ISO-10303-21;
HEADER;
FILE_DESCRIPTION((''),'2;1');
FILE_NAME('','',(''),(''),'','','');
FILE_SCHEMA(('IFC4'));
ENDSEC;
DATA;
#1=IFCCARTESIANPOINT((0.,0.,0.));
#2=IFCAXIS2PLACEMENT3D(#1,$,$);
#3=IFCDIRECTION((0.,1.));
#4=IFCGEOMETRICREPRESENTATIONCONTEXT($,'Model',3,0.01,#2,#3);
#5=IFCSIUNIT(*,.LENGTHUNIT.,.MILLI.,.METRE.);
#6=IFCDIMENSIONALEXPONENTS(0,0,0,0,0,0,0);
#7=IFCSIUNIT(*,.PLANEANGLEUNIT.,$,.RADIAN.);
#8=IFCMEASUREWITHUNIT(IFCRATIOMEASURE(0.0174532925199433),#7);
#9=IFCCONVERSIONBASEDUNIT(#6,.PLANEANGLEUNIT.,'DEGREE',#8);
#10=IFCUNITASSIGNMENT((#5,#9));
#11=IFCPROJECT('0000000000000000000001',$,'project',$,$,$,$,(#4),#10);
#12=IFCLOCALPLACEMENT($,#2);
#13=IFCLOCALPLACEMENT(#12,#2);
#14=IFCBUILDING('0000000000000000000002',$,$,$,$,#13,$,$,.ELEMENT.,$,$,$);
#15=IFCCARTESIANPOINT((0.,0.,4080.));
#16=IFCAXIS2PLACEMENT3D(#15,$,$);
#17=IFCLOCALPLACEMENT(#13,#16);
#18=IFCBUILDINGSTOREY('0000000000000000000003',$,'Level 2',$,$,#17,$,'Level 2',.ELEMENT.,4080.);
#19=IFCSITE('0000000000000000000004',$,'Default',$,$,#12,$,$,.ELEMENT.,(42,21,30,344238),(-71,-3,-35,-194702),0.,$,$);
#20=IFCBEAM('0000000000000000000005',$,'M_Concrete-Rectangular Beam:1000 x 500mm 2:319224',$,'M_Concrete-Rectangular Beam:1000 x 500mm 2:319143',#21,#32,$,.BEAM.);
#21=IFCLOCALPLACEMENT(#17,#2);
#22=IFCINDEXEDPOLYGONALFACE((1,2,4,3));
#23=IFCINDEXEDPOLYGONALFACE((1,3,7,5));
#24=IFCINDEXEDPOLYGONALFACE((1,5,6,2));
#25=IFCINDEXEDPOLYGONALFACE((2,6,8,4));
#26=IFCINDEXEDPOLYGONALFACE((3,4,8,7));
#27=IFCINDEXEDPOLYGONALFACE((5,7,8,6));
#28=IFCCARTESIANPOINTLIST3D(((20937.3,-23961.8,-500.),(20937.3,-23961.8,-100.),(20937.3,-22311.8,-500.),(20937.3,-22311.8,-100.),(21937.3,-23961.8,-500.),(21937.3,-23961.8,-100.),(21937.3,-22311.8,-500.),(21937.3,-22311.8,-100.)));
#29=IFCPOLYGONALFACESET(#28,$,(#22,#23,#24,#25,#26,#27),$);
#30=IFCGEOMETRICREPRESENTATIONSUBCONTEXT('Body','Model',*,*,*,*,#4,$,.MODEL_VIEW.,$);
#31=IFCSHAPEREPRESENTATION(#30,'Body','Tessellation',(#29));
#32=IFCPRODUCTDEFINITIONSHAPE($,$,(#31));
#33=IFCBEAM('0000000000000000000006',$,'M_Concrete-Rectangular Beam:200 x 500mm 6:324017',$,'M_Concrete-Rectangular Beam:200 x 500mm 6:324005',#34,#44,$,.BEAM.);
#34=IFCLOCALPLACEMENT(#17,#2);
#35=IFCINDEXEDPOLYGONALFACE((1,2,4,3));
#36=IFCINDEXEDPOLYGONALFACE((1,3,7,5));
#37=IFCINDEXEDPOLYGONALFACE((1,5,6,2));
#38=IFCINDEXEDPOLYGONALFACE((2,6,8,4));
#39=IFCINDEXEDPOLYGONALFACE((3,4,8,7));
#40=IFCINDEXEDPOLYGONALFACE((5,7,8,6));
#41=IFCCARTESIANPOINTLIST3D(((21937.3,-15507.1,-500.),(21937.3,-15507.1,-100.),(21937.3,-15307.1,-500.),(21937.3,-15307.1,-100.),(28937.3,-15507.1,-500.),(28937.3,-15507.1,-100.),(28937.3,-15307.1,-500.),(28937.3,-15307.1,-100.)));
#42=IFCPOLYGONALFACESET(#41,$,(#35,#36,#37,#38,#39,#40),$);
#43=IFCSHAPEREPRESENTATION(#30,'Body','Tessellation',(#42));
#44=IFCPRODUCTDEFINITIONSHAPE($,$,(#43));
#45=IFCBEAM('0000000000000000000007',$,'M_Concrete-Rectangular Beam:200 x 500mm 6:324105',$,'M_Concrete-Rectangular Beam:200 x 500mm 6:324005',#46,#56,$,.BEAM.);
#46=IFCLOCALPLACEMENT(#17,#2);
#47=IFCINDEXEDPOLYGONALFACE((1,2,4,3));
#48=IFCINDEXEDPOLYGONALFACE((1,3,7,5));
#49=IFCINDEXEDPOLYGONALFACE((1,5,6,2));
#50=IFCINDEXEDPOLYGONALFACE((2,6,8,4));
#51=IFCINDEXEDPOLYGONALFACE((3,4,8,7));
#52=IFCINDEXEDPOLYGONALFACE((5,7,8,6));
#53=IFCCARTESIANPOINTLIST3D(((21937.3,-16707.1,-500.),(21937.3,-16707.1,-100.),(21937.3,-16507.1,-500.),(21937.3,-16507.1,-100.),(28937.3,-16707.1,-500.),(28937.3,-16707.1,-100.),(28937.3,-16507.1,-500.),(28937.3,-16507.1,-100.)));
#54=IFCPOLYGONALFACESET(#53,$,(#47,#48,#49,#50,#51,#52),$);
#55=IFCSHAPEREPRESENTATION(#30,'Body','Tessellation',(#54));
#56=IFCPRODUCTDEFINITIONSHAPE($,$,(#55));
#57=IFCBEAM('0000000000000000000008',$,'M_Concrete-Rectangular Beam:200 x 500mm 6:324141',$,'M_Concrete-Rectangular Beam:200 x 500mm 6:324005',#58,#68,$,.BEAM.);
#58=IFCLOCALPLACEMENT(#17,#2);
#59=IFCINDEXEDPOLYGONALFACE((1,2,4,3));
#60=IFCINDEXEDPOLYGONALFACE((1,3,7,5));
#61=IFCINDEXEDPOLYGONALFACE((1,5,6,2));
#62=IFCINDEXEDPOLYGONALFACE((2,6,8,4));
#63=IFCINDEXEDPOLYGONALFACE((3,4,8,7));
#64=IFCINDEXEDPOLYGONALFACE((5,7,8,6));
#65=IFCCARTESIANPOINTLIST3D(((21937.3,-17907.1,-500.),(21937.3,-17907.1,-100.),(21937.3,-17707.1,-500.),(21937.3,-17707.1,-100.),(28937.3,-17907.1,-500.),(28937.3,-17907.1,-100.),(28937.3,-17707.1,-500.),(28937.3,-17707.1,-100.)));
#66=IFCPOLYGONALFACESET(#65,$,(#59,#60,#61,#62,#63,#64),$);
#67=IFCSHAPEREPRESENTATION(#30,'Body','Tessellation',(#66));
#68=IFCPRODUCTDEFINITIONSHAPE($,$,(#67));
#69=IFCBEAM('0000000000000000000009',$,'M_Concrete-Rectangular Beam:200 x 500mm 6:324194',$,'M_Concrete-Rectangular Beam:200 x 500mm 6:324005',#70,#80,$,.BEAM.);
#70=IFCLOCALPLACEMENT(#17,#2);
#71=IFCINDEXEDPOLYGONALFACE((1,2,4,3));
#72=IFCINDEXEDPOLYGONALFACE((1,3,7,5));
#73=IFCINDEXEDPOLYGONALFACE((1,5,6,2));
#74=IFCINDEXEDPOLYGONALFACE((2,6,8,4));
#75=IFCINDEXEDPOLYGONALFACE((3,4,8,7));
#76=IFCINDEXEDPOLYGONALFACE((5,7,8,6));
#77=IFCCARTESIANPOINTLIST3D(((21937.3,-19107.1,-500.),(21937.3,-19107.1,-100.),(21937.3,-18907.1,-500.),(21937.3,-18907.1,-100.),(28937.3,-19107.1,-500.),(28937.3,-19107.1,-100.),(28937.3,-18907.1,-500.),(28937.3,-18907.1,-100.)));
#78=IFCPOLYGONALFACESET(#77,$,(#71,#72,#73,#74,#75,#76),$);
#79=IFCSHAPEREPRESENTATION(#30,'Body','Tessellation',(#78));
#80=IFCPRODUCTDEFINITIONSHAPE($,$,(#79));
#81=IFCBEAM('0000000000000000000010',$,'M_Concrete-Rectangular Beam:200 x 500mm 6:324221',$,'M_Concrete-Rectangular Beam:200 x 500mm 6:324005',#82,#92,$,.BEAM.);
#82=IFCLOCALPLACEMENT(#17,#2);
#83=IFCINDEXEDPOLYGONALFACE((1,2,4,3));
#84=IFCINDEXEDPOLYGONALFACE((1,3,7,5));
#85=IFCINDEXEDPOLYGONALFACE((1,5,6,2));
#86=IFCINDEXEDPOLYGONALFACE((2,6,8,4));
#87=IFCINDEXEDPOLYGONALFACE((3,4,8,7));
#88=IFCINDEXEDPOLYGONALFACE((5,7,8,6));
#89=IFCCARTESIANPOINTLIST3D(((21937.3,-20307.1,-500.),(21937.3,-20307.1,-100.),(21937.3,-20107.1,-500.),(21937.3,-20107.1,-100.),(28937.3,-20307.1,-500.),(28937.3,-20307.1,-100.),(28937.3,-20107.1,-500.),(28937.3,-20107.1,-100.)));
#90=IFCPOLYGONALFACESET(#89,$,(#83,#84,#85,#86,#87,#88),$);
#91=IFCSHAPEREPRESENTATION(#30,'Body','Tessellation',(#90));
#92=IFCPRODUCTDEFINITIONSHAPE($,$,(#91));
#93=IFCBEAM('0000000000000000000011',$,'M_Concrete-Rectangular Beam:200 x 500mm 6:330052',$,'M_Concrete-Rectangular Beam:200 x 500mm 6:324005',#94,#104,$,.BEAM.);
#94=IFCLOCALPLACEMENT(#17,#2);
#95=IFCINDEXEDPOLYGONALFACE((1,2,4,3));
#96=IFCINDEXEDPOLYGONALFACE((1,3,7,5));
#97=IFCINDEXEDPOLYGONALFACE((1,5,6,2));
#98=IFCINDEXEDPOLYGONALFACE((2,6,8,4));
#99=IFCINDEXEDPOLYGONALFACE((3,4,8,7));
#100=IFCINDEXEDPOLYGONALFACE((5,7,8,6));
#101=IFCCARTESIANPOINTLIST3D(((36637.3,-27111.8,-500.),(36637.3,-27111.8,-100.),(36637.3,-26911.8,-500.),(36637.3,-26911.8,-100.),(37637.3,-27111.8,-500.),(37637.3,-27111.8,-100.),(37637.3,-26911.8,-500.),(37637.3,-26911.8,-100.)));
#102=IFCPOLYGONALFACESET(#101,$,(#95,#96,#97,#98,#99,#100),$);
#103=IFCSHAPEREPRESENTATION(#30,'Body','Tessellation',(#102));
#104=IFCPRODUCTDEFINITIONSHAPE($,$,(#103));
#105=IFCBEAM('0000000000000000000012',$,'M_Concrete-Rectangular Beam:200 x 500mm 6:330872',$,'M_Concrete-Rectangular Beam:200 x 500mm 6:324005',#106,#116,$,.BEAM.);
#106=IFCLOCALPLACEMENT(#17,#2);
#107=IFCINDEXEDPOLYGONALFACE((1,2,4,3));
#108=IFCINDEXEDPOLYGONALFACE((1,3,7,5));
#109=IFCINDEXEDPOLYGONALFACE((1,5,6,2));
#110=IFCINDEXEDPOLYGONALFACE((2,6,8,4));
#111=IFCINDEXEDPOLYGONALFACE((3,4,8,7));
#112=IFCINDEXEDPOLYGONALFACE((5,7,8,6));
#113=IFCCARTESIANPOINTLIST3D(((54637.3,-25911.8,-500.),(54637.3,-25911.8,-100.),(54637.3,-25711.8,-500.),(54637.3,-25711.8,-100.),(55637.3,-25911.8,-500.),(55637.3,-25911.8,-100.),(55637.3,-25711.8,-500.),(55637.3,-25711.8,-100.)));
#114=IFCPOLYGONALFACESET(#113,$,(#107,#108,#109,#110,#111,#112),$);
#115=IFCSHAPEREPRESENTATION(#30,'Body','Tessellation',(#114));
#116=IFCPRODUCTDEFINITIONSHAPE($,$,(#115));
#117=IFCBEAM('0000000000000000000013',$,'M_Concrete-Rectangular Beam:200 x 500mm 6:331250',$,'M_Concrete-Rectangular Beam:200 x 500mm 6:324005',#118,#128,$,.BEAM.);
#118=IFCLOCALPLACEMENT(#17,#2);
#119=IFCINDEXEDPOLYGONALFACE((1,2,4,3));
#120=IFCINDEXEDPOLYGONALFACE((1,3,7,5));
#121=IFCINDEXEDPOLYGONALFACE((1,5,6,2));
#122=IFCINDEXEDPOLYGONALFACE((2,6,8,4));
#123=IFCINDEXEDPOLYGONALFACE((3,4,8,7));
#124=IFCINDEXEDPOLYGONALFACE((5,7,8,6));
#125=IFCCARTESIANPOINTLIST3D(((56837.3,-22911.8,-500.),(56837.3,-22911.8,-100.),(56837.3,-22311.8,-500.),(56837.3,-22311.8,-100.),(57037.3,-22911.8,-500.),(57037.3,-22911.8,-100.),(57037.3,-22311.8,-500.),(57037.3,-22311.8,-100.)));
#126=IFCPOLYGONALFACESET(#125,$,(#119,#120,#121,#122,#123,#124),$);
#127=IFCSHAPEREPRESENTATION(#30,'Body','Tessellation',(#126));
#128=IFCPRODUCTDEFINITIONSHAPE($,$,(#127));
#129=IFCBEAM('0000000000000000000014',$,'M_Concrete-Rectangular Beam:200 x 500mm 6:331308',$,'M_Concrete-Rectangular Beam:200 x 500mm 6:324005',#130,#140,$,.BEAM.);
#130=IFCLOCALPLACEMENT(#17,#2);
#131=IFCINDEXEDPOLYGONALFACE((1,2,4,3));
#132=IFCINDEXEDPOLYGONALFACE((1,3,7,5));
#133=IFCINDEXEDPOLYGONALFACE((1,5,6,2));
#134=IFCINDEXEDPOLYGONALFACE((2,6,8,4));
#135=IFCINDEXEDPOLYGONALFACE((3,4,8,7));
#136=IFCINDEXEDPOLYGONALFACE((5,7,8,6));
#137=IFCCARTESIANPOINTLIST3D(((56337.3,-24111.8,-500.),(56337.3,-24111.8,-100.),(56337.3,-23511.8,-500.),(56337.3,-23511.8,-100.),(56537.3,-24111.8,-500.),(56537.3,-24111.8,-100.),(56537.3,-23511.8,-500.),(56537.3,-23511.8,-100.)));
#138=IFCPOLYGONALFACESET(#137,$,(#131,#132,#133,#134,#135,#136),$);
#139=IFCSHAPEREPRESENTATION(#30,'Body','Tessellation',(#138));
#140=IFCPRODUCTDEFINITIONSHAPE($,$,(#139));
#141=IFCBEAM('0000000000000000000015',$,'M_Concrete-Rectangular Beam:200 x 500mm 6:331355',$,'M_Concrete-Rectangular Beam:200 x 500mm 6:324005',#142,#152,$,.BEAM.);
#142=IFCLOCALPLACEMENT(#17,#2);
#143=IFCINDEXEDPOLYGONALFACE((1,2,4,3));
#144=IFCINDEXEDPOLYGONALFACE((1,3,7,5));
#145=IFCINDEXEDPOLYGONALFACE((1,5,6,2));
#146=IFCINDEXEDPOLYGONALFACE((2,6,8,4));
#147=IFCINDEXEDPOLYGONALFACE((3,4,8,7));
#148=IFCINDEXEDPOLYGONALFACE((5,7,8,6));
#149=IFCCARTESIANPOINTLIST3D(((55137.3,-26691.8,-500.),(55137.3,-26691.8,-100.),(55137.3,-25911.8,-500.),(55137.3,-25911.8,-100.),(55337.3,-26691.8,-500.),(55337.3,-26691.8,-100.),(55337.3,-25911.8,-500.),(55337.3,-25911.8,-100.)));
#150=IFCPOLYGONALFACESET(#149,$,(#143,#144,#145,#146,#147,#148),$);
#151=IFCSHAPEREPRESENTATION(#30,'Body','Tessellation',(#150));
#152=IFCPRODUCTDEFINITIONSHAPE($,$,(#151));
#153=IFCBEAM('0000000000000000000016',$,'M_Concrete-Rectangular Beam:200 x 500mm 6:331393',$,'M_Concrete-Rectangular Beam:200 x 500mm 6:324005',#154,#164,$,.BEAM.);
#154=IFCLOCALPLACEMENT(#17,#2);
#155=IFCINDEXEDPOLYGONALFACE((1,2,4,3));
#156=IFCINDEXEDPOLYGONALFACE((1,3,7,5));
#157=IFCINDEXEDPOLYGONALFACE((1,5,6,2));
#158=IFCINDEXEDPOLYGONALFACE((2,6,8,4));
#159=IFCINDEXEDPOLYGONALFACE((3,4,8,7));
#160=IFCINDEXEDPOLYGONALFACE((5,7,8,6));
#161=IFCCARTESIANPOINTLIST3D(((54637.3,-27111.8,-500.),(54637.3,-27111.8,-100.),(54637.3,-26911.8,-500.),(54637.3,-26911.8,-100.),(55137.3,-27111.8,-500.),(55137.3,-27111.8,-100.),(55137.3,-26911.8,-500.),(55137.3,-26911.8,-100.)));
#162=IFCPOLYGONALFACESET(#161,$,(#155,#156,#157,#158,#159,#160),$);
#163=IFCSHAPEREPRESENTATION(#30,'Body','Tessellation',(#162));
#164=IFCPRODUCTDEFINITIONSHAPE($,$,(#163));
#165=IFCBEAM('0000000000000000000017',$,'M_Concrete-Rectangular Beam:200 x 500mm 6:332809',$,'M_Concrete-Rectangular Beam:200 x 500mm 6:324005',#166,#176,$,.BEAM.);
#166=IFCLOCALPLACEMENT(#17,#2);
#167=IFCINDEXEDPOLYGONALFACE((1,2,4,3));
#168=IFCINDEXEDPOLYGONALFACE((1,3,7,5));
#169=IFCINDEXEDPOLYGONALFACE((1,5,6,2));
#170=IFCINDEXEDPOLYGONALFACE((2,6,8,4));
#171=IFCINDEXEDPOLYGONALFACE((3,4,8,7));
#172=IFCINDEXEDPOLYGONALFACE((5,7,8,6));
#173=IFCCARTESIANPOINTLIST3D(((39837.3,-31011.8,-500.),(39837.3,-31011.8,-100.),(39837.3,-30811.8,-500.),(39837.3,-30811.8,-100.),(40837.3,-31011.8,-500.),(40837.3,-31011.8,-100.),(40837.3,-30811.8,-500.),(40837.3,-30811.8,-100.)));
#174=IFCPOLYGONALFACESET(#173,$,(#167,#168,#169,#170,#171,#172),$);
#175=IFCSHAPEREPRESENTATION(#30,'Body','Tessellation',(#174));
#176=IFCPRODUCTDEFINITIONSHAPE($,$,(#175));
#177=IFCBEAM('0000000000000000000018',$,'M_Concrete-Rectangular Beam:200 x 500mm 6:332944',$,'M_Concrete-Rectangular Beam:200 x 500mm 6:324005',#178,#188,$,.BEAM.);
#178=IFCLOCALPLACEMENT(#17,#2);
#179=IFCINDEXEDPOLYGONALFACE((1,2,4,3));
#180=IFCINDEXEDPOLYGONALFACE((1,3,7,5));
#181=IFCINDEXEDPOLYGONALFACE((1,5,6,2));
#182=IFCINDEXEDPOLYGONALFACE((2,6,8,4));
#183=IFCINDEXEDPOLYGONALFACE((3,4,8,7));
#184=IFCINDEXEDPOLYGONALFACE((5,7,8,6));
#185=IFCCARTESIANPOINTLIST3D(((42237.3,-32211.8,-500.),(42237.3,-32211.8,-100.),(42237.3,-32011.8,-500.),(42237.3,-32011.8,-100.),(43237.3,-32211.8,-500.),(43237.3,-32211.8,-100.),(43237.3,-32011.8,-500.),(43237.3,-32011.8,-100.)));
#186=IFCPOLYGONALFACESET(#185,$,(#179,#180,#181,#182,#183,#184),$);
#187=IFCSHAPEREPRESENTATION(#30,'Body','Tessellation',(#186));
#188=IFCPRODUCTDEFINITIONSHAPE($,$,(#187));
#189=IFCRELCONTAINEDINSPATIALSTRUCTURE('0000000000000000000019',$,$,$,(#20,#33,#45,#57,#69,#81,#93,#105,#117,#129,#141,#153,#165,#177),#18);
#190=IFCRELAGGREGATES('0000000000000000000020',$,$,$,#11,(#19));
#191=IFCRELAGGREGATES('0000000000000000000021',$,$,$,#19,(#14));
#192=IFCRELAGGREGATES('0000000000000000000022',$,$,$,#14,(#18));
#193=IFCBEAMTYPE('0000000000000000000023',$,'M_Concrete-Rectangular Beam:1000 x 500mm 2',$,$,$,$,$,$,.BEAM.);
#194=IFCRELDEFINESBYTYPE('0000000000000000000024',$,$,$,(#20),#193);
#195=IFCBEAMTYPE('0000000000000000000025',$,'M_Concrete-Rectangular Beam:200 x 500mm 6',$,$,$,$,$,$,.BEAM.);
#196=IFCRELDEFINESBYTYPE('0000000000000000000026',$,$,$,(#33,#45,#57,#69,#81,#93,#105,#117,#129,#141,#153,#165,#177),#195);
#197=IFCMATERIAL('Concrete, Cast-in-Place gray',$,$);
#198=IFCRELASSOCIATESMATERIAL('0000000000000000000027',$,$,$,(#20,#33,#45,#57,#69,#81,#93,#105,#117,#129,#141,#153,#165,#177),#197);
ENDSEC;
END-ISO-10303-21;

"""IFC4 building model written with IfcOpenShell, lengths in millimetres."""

from ifc_helpers import new_model, entity, si_unit, converted_unit, direction, frame, frame_2d, origin, place, context, subcontext, project, spatial, rectangle, extrude, material, type_object, element, save


model = new_model("IFC4")

# Units and contexts
model_context = context("Model", 3, precision=0.01, world=origin(), true_north=direction((0.0, 1.0)))
body_context = subcontext(model_context, "Body", "Model", "MODEL_VIEW")
ifc_project = project(units=[si_unit("LENGTHUNIT", "METRE", prefix="MILLI"), converted_unit("PLANEANGLEUNIT", "DEGREE", entity("IfcRatioMeasure", 0.0174532925199433), si_unit("PLANEANGLEUNIT", "RADIAN"), dimensions=[0, 0, 0, 0, 0, 0, 0])], contexts=[model_context])

# Site, building, storey
site_placement = place(None, origin())
site = spatial("IfcSite", under=ifc_project, at=site_placement, Name="Default", CompositionType="ELEMENT", RefLatitude=(42, 21, 30, 344238), RefLongitude=(-71, -3, -35, -194702), RefElevation=0.0)
building_placement = place(site_placement, origin())
building = spatial("IfcBuilding", under=site, at=building_placement, CompositionType="ELEMENT")
storey_placement = place(building_placement, frame((0.0, 0.0, 4080.0)))
storey = spatial("IfcBuildingStorey", under=building, at=storey_placement, Name="Level 2", LongName="Level 2", CompositionType="ELEMENT", Elevation=4080.0)

# Beams
ifc_material_1 = material(Name="Concrete, Cast-in-Place gray")
beam_type_1 = type_object("IfcBeamType", Name="M_Concrete-Rectangular Beam:1000 x 500mm 2", PredefinedType="BEAM")
beam_1_placement = place(storey_placement, frame((21437.3, -21811.8, 0.0), z_axis=(0.0, 0.0, 1.0), x_axis=(0.0, -1.0, 0.0)))
element("IfcBeam", 1, at=beam_1_placement, inside=storey, type_object=beam_type_1, material=ifc_material_1, Name="M_Concrete-Rectangular Beam:1000 x 500mm 2:319224", ObjectType="M_Concrete-Rectangular Beam:1000 x 500mm 2:319143", PredefinedType="BEAM", context=body_context, shape_type="SweptSolid", body=[
    extrude(rectangle(XDim=400.0, YDim=1000.0, at=frame_2d((0.0, 0.0), x_axis=(1.0, 0.0))), frame((500.0, 0.0, -300.0), z_axis=(1.0, 0.0, 0.0), x_axis=(0.0, 0.0, -1.0)), (0.0, 0.0, 1.0), 1650.0),
])
beam_type_2 = type_object("IfcBeamType", Name="M_Concrete-Rectangular Beam:200 x 500mm 6", PredefinedType="BEAM")
for number, where, name in (
    (2, (21437.3, -15407.1, 0.0), "M_Concrete-Rectangular Beam:200 x 500mm 6:324017"),
    (3, (21437.3, -16607.1, 0.0), "M_Concrete-Rectangular Beam:200 x 500mm 6:324105"),
    (4, (21437.3, -17807.1, 0.0), "M_Concrete-Rectangular Beam:200 x 500mm 6:324141"),
):
    element("IfcBeam", number, at=place(storey_placement, frame(where)), inside=storey, type_object=beam_type_2, material=ifc_material_1, Name=name, ObjectType="M_Concrete-Rectangular Beam:200 x 500mm 6:324005", PredefinedType="BEAM", context=body_context, shape_type="SweptSolid", body=[
        extrude(rectangle(XDim=400.0, YDim=200.0, at=frame_2d((0.0, 0.0), x_axis=(1.0, 0.0))), frame((500.0, 0.0, -300.0), z_axis=(1.0, 0.0, 0.0), x_axis=(0.0, 0.0, -1.0)), (0.0, 0.0, 1.0), 7000.0),
    ])
beam_2_placement = place(storey_placement, frame((21437.3, -19007.1, 0.0)))
element("IfcBeam", 5, at=beam_2_placement, inside=storey, type_object=beam_type_2, material=ifc_material_1, Name="M_Concrete-Rectangular Beam:200 x 500mm 6:324194", ObjectType="M_Concrete-Rectangular Beam:200 x 500mm 6:324005", PredefinedType="BEAM", context=body_context, shape_type="SweptSolid", body=[
    extrude(rectangle(XDim=400.0, YDim=200.0, at=frame_2d((0.0, 0.0), x_axis=(1.0, 0.0))), frame((500.0, 0.0, -300.0), z_axis=(1.0, 0.0, 0.0), x_axis=(0.0, 0.0, -1.0)), (0.0, 0.0, 1.0), 7000.0),
])
beam_3_placement = place(storey_placement, frame((21437.3, -20207.1, 0.0)))
element("IfcBeam", 6, at=beam_3_placement, inside=storey, type_object=beam_type_2, material=ifc_material_1, Name="M_Concrete-Rectangular Beam:200 x 500mm 6:324221", ObjectType="M_Concrete-Rectangular Beam:200 x 500mm 6:324005", PredefinedType="BEAM", context=body_context, shape_type="SweptSolid", body=[
    extrude(rectangle(XDim=400.0, YDim=200.0, at=frame_2d((0.0, 0.0), x_axis=(1.0, 0.0))), frame((500.0, 0.0, -300.0), z_axis=(1.0, 0.0, 0.0), x_axis=(0.0, 0.0, -1.0)), (0.0, 0.0, 1.0), 7000.0),
])
beam_4_placement = place(storey_placement, frame((36537.3, -27011.8, 0.0)))
element("IfcBeam", 7, at=beam_4_placement, inside=storey, type_object=beam_type_2, material=ifc_material_1, Name="M_Concrete-Rectangular Beam:200 x 500mm 6:330052", ObjectType="M_Concrete-Rectangular Beam:200 x 500mm 6:324005", PredefinedType="BEAM", context=body_context, shape_type="SweptSolid", body=[
    extrude(rectangle(XDim=400.0, YDim=200.0, at=frame_2d((0.0, 0.0), x_axis=(1.0, 0.0))), frame((100.0, 0.0, -300.0), z_axis=(1.0, 0.0, 0.0), x_axis=(0.0, 0.0, -1.0)), (0.0, 0.0, 1.0), 1000.0),
])
beam_5_placement = place(storey_placement, frame((54137.3, -25811.8, 0.0)))
element("IfcBeam", 8, at=beam_5_placement, inside=storey, type_object=beam_type_2, material=ifc_material_1, Name="M_Concrete-Rectangular Beam:200 x 500mm 6:330872", ObjectType="M_Concrete-Rectangular Beam:200 x 500mm 6:324005", PredefinedType="BEAM", context=body_context, shape_type="SweptSolid", body=[
    extrude(rectangle(XDim=400.0, YDim=200.0, at=frame_2d((0.0, 0.0), x_axis=(1.0, 0.0))), frame((500.0, 0.0, -300.0), z_axis=(1.0, 0.0, 0.0), x_axis=(0.0, 0.0, -1.0)), (0.0, 0.0, 1.0), 1000.0),
])
beam_6_placement = place(storey_placement, frame((56937.3, -21811.8, 0.0), z_axis=(0.0, 0.0, 1.0), x_axis=(0.0, -1.0, 0.0)))
element("IfcBeam", 9, at=beam_6_placement, inside=storey, type_object=beam_type_2, material=ifc_material_1, Name="M_Concrete-Rectangular Beam:200 x 500mm 6:331250", ObjectType="M_Concrete-Rectangular Beam:200 x 500mm 6:324005", PredefinedType="BEAM", context=body_context, shape_type="SweptSolid", body=[
    extrude(rectangle(XDim=400.0, YDim=200.0, at=frame_2d((0.0, 0.0), x_axis=(1.0, 0.0))), frame((500.0, 0.0, -300.0), z_axis=(1.0, 0.0, 0.0), x_axis=(0.0, 0.0, -1.0)), (0.0, 0.0, 1.0), 600.0),
])
beam_7_placement = place(storey_placement, frame((56437.3, -23411.8, 0.0), z_axis=(0.0, 0.0, 1.0), x_axis=(0.0, -1.0, 0.0)))
element("IfcBeam", 10, at=beam_7_placement, inside=storey, type_object=beam_type_2, material=ifc_material_1, Name="M_Concrete-Rectangular Beam:200 x 500mm 6:331308", ObjectType="M_Concrete-Rectangular Beam:200 x 500mm 6:324005", PredefinedType="BEAM", context=body_context, shape_type="SweptSolid", body=[
    extrude(rectangle(XDim=400.0, YDim=200.0, at=frame_2d((0.0, 0.0), x_axis=(1.0, 0.0))), frame((100.0, 0.0, -300.0), z_axis=(1.0, 0.0, 0.0), x_axis=(0.0, 0.0, -1.0)), (0.0, 0.0, 1.0), 600.0),
])
beam_8_placement = place(storey_placement, frame((55237.3, -25811.8, 0.0), z_axis=(0.0, 0.0, 1.0), x_axis=(0.0, -1.0, 0.0)))
element("IfcBeam", 11, at=beam_8_placement, inside=storey, type_object=beam_type_2, material=ifc_material_1, Name="M_Concrete-Rectangular Beam:200 x 500mm 6:331355", ObjectType="M_Concrete-Rectangular Beam:200 x 500mm 6:324005", PredefinedType="BEAM", context=body_context, shape_type="SweptSolid", body=[
    extrude(rectangle(XDim=400.0, YDim=200.0, at=frame_2d((0.0, 0.0), x_axis=(1.0, 0.0))), frame((100.0, 0.0, -300.0), z_axis=(1.0, 0.0, 0.0), x_axis=(0.0, 0.0, -1.0)), (0.0, 0.0, 1.0), 780.0),
])
beam_9_placement = place(storey_placement, frame((54137.3, -27011.8, 0.0)))
element("IfcBeam", 12, at=beam_9_placement, inside=storey, type_object=beam_type_2, material=ifc_material_1, Name="M_Concrete-Rectangular Beam:200 x 500mm 6:331393", ObjectType="M_Concrete-Rectangular Beam:200 x 500mm 6:324005", PredefinedType="BEAM", context=body_context, shape_type="SweptSolid", body=[
    extrude(rectangle(XDim=400.0, YDim=200.0, at=frame_2d((0.0, 0.0), x_axis=(1.0, 0.0))), frame((500.0, 0.0, -300.0), z_axis=(1.0, 0.0, 0.0), x_axis=(0.0, 0.0, -1.0)), (0.0, 0.0, 1.0), 500.0),
])
beam_10_placement = place(storey_placement, frame((39637.3, -30911.8, 0.0)))
element("IfcBeam", 13, at=beam_10_placement, inside=storey, type_object=beam_type_2, material=ifc_material_1, Name="M_Concrete-Rectangular Beam:200 x 500mm 6:332809", ObjectType="M_Concrete-Rectangular Beam:200 x 500mm 6:324005", PredefinedType="BEAM", context=body_context, shape_type="SweptSolid", body=[
    extrude(rectangle(XDim=400.0, YDim=200.0, at=frame_2d((0.0, 0.0), x_axis=(1.0, 0.0))), frame((200.0, 0.0, -300.0), z_axis=(1.0, 0.0, 0.0), x_axis=(0.0, 0.0, -1.0)), (0.0, 0.0, 1.0), 1000.0),
])
beam_11_placement = place(storey_placement, frame((42137.3, -32111.8, 0.0)))
element("IfcBeam", 14, at=beam_11_placement, inside=storey, type_object=beam_type_2, material=ifc_material_1, Name="M_Concrete-Rectangular Beam:200 x 500mm 6:332944", ObjectType="M_Concrete-Rectangular Beam:200 x 500mm 6:324005", PredefinedType="BEAM", context=body_context, shape_type="SweptSolid", body=[
    extrude(rectangle(XDim=400.0, YDim=200.0, at=frame_2d((0.0, 0.0), x_axis=(1.0, 0.0))), frame((100.0, 0.0, -300.0), z_axis=(1.0, 0.0, 0.0), x_axis=(0.0, 0.0, -1.0)), (0.0, 0.0, 1.0), 1000.0),
])

save(model, "model.ifc")
